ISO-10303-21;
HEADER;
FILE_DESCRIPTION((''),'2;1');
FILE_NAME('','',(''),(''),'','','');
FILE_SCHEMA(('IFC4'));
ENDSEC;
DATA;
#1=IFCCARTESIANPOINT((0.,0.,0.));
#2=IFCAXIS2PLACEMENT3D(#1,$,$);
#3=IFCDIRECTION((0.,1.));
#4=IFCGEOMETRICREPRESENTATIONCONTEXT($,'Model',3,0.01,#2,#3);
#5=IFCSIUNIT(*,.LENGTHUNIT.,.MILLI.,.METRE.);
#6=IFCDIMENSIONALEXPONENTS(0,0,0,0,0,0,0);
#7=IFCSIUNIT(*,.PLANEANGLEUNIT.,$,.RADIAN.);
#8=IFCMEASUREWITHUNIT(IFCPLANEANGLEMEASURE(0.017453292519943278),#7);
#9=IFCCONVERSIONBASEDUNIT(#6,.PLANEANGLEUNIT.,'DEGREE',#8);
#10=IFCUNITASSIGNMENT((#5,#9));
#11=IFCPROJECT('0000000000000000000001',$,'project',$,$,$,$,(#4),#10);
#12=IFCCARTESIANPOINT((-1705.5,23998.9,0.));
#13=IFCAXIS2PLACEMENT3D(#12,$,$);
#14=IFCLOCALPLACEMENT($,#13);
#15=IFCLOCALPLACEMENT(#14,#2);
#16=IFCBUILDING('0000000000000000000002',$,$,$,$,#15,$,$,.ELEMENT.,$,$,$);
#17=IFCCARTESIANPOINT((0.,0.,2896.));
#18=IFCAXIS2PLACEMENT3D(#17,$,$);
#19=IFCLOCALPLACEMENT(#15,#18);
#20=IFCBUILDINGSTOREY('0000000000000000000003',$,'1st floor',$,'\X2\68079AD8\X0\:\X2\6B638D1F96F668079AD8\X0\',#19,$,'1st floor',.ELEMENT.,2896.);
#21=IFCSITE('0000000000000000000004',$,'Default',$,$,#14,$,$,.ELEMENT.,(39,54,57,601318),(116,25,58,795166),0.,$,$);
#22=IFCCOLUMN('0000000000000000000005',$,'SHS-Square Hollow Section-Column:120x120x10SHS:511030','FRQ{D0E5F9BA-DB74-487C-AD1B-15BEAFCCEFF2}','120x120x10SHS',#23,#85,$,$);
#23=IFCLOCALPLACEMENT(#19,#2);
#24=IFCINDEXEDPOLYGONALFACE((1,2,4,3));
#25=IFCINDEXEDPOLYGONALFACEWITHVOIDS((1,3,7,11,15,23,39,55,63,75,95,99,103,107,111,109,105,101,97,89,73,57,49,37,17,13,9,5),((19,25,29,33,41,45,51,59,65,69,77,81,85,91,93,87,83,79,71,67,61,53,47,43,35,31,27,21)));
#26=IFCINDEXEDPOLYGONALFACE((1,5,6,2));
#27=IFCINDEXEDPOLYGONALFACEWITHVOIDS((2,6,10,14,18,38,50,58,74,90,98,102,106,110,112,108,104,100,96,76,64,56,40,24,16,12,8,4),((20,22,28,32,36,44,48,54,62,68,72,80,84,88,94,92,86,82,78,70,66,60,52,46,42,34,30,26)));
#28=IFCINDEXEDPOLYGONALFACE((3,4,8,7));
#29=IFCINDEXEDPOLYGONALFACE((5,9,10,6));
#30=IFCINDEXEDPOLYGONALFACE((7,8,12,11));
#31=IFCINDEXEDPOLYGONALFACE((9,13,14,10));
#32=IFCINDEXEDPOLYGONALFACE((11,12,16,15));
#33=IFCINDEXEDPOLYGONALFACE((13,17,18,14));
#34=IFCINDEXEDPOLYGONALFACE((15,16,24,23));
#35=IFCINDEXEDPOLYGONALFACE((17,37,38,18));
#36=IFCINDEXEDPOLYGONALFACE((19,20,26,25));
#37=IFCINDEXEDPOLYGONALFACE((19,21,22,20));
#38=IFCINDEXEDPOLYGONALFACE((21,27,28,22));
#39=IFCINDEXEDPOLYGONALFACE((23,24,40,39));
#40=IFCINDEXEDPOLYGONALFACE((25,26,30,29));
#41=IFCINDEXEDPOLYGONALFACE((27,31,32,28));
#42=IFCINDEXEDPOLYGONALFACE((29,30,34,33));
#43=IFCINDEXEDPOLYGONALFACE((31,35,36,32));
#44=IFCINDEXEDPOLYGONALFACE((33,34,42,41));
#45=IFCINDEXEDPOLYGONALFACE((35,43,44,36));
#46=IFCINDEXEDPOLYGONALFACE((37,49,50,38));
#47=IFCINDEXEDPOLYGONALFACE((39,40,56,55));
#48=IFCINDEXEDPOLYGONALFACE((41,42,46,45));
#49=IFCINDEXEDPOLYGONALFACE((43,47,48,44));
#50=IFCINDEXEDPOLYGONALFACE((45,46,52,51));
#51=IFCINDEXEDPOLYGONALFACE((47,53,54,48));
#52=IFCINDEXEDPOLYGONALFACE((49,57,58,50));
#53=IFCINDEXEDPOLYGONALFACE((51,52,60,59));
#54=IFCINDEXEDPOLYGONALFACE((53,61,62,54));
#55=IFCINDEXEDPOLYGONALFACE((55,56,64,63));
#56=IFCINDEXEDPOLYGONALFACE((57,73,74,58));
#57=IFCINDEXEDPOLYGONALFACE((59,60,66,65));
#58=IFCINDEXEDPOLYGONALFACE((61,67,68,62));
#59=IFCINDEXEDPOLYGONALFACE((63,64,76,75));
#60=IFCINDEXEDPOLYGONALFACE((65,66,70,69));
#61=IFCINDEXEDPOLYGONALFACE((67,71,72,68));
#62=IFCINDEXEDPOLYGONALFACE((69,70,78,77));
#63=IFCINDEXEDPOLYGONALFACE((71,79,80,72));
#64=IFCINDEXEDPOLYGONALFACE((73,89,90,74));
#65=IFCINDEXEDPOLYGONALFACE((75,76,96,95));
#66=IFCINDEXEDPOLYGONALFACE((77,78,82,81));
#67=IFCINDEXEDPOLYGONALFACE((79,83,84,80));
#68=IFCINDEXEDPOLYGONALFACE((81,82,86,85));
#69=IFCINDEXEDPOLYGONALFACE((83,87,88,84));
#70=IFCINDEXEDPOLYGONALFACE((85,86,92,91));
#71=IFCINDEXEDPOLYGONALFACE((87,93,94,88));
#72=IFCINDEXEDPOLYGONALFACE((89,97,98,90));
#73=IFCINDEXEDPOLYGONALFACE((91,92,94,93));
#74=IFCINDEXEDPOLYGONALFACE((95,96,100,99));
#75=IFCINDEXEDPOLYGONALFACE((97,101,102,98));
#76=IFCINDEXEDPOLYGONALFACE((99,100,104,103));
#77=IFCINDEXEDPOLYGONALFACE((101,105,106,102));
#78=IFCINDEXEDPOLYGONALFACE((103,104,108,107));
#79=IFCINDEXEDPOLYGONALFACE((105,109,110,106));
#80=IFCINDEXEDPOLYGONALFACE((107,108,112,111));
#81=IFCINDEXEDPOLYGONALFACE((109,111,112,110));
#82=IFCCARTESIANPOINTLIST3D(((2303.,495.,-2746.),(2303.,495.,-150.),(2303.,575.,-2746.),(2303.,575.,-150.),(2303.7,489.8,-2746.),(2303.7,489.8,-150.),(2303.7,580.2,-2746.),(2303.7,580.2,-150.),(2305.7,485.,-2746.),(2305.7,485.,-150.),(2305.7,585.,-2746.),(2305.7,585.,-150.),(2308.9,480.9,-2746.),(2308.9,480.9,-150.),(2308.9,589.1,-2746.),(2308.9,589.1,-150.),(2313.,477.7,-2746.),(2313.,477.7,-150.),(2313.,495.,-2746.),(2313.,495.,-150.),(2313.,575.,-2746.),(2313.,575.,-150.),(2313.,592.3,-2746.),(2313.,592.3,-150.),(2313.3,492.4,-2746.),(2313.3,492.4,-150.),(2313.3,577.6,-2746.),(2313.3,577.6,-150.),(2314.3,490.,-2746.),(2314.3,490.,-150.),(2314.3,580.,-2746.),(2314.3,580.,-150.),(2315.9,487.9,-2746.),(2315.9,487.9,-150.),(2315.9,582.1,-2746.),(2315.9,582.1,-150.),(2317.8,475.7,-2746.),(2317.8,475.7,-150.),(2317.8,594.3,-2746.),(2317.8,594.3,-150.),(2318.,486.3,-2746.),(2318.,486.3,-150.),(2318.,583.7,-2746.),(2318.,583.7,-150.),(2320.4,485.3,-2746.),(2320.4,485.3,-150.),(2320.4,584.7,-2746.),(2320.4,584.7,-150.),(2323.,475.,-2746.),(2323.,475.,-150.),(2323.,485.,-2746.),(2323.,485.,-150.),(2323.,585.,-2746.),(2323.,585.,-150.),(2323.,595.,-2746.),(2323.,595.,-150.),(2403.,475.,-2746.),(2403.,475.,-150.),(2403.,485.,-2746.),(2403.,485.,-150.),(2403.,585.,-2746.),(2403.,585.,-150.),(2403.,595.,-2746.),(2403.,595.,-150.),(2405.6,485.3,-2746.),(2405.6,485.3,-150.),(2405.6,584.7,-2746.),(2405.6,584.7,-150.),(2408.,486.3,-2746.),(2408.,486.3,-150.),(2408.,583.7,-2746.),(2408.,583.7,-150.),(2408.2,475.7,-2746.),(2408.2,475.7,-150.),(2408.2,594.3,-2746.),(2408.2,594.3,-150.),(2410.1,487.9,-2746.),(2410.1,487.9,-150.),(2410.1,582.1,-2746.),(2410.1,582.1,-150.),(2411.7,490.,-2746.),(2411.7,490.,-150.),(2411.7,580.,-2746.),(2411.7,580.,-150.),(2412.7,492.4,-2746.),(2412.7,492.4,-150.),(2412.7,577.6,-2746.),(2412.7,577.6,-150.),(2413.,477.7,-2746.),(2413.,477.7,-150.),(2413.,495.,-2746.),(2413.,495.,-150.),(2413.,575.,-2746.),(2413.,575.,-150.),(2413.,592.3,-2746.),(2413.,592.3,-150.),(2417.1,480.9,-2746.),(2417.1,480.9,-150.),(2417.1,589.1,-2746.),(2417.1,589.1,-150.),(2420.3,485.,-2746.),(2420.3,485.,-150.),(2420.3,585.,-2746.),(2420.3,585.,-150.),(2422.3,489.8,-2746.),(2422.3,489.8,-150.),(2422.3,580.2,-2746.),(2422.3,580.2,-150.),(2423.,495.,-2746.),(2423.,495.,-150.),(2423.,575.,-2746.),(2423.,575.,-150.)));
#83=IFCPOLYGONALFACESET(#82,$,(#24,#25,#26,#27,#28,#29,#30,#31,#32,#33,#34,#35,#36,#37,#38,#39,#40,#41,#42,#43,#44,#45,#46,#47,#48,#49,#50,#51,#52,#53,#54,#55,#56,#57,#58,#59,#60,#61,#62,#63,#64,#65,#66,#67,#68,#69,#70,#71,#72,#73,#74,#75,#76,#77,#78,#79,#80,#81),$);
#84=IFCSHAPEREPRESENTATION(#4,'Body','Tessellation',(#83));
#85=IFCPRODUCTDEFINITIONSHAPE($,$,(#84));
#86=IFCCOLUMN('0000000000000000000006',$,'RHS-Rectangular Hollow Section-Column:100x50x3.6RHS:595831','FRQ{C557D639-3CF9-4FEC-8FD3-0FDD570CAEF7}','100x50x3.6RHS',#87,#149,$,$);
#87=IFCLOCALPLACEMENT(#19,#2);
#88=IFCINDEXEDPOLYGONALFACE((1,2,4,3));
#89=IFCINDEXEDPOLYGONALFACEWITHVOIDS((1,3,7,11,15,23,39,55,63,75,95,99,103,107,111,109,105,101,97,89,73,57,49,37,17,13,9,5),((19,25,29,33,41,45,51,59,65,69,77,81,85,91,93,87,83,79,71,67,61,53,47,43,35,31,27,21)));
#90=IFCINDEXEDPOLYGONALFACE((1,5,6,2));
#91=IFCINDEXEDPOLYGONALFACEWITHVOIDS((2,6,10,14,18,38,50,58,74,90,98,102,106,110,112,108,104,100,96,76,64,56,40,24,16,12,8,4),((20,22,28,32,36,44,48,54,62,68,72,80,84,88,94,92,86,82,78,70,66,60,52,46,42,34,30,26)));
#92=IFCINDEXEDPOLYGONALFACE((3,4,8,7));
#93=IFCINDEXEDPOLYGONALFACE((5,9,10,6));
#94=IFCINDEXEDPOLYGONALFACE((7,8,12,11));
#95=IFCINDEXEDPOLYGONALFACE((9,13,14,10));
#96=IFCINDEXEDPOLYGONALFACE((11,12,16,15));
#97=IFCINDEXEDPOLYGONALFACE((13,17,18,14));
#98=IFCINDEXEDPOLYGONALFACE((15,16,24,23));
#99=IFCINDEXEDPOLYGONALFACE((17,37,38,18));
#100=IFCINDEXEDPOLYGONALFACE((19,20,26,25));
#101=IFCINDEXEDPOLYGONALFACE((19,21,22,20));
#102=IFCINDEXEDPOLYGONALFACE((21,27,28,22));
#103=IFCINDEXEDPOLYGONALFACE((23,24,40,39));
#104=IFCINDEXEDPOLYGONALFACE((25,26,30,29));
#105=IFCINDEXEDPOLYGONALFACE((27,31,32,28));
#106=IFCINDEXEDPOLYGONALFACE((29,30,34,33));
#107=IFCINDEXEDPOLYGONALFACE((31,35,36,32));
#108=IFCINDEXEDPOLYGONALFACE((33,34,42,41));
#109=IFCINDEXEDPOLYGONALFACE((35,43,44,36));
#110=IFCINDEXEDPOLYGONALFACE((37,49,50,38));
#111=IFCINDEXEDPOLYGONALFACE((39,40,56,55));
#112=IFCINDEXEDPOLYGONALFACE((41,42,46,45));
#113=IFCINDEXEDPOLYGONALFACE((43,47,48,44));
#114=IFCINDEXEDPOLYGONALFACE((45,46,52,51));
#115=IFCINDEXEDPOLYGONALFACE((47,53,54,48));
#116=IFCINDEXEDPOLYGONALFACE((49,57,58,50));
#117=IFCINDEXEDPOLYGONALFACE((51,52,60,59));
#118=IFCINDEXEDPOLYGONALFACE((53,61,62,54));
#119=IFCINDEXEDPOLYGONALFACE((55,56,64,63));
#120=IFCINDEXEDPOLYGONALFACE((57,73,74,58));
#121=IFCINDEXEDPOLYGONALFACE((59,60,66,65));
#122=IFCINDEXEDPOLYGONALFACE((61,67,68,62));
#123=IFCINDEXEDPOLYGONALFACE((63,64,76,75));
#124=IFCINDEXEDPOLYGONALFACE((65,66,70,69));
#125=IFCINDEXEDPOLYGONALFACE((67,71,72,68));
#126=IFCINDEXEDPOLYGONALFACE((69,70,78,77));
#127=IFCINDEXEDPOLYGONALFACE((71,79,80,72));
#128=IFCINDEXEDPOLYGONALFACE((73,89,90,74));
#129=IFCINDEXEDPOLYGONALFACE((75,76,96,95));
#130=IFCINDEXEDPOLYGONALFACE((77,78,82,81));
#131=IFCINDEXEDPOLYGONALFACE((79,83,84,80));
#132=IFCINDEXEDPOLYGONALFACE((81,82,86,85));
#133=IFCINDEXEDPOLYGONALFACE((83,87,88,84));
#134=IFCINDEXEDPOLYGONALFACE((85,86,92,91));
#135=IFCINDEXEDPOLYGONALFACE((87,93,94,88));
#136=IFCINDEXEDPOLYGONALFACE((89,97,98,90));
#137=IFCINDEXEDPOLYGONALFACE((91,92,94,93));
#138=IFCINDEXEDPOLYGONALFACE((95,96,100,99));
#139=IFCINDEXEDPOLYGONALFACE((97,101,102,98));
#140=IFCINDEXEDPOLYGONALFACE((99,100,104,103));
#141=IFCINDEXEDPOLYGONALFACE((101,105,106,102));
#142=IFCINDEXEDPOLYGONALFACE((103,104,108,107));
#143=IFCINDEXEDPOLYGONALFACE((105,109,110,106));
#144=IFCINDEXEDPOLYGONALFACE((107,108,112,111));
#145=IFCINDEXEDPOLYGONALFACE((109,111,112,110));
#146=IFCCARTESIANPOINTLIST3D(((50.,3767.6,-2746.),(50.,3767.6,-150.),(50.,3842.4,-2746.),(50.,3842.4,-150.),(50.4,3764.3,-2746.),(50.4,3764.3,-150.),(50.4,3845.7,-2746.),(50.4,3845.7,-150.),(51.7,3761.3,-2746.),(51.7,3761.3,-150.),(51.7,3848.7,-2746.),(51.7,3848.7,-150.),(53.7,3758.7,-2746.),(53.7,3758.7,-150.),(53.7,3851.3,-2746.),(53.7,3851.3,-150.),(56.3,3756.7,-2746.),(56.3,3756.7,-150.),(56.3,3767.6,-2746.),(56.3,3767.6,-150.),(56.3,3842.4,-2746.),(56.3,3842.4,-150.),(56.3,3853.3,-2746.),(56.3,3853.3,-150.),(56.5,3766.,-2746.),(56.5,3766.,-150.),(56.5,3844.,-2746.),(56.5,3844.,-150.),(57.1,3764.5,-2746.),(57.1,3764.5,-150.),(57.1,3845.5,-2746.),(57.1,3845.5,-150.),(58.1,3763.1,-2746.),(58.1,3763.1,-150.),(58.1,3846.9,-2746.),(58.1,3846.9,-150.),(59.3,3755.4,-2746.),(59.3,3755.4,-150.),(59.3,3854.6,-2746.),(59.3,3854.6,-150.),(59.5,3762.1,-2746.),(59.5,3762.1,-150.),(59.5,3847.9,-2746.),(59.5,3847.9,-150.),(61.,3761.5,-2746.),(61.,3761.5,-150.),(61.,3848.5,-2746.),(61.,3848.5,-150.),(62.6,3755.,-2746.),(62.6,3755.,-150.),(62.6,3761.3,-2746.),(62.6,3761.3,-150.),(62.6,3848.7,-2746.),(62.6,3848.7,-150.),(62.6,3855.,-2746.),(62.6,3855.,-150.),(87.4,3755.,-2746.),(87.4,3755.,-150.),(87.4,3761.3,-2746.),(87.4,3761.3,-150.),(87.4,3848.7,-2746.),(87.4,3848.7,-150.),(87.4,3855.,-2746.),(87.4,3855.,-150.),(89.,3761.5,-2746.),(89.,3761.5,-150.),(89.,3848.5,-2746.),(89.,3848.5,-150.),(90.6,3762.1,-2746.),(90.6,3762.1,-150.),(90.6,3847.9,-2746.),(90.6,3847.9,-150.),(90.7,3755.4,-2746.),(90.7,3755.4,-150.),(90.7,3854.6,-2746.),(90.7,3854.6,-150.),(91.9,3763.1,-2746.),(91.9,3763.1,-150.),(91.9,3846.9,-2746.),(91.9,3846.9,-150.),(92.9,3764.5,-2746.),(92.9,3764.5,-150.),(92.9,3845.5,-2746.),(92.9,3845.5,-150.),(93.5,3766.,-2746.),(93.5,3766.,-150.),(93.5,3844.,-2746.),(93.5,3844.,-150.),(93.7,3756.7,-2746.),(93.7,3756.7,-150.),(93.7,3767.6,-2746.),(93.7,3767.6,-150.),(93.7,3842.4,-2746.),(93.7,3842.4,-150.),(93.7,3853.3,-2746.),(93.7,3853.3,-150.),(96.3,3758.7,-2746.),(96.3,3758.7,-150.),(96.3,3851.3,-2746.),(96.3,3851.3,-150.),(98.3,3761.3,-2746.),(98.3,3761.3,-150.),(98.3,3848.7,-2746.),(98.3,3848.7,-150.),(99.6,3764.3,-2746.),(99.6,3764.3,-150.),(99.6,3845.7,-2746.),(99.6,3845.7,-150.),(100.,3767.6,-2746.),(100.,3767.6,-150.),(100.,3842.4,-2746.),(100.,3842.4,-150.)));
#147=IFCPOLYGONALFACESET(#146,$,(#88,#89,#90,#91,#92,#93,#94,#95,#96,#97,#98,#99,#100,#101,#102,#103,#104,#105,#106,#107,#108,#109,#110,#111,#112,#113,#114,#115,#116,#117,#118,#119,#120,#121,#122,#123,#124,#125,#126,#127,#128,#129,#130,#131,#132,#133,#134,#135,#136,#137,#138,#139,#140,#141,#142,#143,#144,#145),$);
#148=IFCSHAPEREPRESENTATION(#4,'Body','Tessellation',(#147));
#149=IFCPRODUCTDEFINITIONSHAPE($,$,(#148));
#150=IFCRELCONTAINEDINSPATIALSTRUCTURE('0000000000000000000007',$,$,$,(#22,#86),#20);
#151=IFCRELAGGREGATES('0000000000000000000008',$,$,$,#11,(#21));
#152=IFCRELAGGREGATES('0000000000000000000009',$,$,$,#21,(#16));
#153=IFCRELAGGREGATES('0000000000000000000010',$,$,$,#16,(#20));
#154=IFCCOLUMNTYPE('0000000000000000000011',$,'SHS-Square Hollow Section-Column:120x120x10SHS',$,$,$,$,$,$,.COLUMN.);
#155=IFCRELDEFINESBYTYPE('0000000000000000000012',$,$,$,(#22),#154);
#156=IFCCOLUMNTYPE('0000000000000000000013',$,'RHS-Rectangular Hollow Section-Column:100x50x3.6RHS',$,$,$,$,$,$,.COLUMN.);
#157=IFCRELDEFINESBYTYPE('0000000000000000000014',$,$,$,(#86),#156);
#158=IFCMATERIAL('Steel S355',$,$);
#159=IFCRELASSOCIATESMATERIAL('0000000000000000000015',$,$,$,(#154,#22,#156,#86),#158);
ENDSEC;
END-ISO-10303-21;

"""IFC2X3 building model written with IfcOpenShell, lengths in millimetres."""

from ifc_helpers import new_model, entity, si_unit, converted_unit, direction, frame, origin, origin_2d, place, context, project, spatial, hollow_rectangle, extrude, clip, halfspace, material, type_object, element, save


model = new_model("IFC2X3")

# Units and contexts
model_context = context("Model", 3, precision=0.01, world=origin(), true_north=direction((0.0, 1.0)))
ifc_project = project(units=[si_unit("LENGTHUNIT", "METRE", prefix="MILLI"), converted_unit("PLANEANGLEUNIT", "DEGREE", entity("IfcPlaneAngleMeasure", 0.017453292519943278), si_unit("PLANEANGLEUNIT", "RADIAN"), dimensions=[0, 0, 0, 0, 0, 0, 0])], contexts=[model_context])

# Site, building, storey
site_placement = place(None, frame((-1705.5, 23998.9, 0.0)))
site = spatial("IfcSite", under=ifc_project, at=site_placement, Name="Default", CompositionType="ELEMENT", RefLatitude=(39, 54, 57, 601318), RefLongitude=(116, 25, 58, 795166), RefElevation=0.0)
building_placement = place(site_placement, origin())
building = spatial("IfcBuilding", under=site, at=building_placement, CompositionType="ELEMENT")
storey_placement = place(building_placement, frame((0.0, 0.0, 2896.0)))
storey = spatial("IfcBuildingStorey", under=building, at=storey_placement, Name="1st floor", ObjectType="标高:正负零标高", LongName="1st floor", CompositionType="ELEMENT", Elevation=2896.0)

# Column
ifc_material_1 = material(Name="Steel S355")
column_type_1 = type_object("IfcColumnType", Name="SHS-Square Hollow Section-Column:120x120x10SHS", PredefinedType="COLUMN", material=ifc_material_1)
column_1_placement = place(storey_placement, frame((2363.0, 535.0, -150.0), z_axis=(0.0, 0.0, 1.0), x_axis=(0.0, -1.0, 0.0)))
element("IfcColumn", 1, at=column_1_placement, inside=storey, type_object=column_type_1, material=ifc_material_1, Name="SHS-Square Hollow Section-Column:120x120x10SHS:511030", Description="FRQ{D0E5F9BA-DB74-487C-AD1B-15BEAFCCEFF2}", ObjectType="120x120x10SHS", context=model_context, shape_type="Clipping", body=[
    clip(extrude(hollow_rectangle(XDim=120.0, YDim=120.0, WallThickness=10.0, InnerFilletRadius=10.0, OuterFilletRadius=20.0, at=origin_2d()), origin(), (0.0, 0.0, -1.0), 2680.9), halfspace(frame((535.0, -2363.0, -2596.0), z_axis=(0.0, 0.0, 1.0), x_axis=(0.0, 1.0, 0.0)), True)),
])

# Column
column_type_2 = type_object("IfcColumnType", Name="RHS-Rectangular Hollow Section-Column:100x50x3.6RHS", PredefinedType="COLUMN", material=ifc_material_1)
column_2_placement = place(storey_placement, frame((75.0, 3805.0, -150.0), z_axis=(0.0, 0.0, 1.0), x_axis=(-1.0, 0.0, 0.0)))
element("IfcColumn", 2, at=column_2_placement, inside=storey, type_object=column_type_2, material=ifc_material_1, Name="RHS-Rectangular Hollow Section-Column:100x50x3.6RHS:595831", Description="FRQ{C557D639-3CF9-4FEC-8FD3-0FDD570CAEF7}", ObjectType="100x50x3.6RHS", context=model_context, shape_type="Clipping", body=[
    clip(extrude(hollow_rectangle(XDim=50.0, YDim=100.0, WallThickness=6.3, InnerFilletRadius=6.3, OuterFilletRadius=12.6, at=origin_2d()), origin(), (0.0, 0.0, -1.0), 2651.9), halfspace(frame((75.0, 3805.0, -2596.0), z_axis=(0.0, 0.0, 1.0), x_axis=(-1.0, 0.0, 0.0)), True)),
])

save(model, "model.ifc")
